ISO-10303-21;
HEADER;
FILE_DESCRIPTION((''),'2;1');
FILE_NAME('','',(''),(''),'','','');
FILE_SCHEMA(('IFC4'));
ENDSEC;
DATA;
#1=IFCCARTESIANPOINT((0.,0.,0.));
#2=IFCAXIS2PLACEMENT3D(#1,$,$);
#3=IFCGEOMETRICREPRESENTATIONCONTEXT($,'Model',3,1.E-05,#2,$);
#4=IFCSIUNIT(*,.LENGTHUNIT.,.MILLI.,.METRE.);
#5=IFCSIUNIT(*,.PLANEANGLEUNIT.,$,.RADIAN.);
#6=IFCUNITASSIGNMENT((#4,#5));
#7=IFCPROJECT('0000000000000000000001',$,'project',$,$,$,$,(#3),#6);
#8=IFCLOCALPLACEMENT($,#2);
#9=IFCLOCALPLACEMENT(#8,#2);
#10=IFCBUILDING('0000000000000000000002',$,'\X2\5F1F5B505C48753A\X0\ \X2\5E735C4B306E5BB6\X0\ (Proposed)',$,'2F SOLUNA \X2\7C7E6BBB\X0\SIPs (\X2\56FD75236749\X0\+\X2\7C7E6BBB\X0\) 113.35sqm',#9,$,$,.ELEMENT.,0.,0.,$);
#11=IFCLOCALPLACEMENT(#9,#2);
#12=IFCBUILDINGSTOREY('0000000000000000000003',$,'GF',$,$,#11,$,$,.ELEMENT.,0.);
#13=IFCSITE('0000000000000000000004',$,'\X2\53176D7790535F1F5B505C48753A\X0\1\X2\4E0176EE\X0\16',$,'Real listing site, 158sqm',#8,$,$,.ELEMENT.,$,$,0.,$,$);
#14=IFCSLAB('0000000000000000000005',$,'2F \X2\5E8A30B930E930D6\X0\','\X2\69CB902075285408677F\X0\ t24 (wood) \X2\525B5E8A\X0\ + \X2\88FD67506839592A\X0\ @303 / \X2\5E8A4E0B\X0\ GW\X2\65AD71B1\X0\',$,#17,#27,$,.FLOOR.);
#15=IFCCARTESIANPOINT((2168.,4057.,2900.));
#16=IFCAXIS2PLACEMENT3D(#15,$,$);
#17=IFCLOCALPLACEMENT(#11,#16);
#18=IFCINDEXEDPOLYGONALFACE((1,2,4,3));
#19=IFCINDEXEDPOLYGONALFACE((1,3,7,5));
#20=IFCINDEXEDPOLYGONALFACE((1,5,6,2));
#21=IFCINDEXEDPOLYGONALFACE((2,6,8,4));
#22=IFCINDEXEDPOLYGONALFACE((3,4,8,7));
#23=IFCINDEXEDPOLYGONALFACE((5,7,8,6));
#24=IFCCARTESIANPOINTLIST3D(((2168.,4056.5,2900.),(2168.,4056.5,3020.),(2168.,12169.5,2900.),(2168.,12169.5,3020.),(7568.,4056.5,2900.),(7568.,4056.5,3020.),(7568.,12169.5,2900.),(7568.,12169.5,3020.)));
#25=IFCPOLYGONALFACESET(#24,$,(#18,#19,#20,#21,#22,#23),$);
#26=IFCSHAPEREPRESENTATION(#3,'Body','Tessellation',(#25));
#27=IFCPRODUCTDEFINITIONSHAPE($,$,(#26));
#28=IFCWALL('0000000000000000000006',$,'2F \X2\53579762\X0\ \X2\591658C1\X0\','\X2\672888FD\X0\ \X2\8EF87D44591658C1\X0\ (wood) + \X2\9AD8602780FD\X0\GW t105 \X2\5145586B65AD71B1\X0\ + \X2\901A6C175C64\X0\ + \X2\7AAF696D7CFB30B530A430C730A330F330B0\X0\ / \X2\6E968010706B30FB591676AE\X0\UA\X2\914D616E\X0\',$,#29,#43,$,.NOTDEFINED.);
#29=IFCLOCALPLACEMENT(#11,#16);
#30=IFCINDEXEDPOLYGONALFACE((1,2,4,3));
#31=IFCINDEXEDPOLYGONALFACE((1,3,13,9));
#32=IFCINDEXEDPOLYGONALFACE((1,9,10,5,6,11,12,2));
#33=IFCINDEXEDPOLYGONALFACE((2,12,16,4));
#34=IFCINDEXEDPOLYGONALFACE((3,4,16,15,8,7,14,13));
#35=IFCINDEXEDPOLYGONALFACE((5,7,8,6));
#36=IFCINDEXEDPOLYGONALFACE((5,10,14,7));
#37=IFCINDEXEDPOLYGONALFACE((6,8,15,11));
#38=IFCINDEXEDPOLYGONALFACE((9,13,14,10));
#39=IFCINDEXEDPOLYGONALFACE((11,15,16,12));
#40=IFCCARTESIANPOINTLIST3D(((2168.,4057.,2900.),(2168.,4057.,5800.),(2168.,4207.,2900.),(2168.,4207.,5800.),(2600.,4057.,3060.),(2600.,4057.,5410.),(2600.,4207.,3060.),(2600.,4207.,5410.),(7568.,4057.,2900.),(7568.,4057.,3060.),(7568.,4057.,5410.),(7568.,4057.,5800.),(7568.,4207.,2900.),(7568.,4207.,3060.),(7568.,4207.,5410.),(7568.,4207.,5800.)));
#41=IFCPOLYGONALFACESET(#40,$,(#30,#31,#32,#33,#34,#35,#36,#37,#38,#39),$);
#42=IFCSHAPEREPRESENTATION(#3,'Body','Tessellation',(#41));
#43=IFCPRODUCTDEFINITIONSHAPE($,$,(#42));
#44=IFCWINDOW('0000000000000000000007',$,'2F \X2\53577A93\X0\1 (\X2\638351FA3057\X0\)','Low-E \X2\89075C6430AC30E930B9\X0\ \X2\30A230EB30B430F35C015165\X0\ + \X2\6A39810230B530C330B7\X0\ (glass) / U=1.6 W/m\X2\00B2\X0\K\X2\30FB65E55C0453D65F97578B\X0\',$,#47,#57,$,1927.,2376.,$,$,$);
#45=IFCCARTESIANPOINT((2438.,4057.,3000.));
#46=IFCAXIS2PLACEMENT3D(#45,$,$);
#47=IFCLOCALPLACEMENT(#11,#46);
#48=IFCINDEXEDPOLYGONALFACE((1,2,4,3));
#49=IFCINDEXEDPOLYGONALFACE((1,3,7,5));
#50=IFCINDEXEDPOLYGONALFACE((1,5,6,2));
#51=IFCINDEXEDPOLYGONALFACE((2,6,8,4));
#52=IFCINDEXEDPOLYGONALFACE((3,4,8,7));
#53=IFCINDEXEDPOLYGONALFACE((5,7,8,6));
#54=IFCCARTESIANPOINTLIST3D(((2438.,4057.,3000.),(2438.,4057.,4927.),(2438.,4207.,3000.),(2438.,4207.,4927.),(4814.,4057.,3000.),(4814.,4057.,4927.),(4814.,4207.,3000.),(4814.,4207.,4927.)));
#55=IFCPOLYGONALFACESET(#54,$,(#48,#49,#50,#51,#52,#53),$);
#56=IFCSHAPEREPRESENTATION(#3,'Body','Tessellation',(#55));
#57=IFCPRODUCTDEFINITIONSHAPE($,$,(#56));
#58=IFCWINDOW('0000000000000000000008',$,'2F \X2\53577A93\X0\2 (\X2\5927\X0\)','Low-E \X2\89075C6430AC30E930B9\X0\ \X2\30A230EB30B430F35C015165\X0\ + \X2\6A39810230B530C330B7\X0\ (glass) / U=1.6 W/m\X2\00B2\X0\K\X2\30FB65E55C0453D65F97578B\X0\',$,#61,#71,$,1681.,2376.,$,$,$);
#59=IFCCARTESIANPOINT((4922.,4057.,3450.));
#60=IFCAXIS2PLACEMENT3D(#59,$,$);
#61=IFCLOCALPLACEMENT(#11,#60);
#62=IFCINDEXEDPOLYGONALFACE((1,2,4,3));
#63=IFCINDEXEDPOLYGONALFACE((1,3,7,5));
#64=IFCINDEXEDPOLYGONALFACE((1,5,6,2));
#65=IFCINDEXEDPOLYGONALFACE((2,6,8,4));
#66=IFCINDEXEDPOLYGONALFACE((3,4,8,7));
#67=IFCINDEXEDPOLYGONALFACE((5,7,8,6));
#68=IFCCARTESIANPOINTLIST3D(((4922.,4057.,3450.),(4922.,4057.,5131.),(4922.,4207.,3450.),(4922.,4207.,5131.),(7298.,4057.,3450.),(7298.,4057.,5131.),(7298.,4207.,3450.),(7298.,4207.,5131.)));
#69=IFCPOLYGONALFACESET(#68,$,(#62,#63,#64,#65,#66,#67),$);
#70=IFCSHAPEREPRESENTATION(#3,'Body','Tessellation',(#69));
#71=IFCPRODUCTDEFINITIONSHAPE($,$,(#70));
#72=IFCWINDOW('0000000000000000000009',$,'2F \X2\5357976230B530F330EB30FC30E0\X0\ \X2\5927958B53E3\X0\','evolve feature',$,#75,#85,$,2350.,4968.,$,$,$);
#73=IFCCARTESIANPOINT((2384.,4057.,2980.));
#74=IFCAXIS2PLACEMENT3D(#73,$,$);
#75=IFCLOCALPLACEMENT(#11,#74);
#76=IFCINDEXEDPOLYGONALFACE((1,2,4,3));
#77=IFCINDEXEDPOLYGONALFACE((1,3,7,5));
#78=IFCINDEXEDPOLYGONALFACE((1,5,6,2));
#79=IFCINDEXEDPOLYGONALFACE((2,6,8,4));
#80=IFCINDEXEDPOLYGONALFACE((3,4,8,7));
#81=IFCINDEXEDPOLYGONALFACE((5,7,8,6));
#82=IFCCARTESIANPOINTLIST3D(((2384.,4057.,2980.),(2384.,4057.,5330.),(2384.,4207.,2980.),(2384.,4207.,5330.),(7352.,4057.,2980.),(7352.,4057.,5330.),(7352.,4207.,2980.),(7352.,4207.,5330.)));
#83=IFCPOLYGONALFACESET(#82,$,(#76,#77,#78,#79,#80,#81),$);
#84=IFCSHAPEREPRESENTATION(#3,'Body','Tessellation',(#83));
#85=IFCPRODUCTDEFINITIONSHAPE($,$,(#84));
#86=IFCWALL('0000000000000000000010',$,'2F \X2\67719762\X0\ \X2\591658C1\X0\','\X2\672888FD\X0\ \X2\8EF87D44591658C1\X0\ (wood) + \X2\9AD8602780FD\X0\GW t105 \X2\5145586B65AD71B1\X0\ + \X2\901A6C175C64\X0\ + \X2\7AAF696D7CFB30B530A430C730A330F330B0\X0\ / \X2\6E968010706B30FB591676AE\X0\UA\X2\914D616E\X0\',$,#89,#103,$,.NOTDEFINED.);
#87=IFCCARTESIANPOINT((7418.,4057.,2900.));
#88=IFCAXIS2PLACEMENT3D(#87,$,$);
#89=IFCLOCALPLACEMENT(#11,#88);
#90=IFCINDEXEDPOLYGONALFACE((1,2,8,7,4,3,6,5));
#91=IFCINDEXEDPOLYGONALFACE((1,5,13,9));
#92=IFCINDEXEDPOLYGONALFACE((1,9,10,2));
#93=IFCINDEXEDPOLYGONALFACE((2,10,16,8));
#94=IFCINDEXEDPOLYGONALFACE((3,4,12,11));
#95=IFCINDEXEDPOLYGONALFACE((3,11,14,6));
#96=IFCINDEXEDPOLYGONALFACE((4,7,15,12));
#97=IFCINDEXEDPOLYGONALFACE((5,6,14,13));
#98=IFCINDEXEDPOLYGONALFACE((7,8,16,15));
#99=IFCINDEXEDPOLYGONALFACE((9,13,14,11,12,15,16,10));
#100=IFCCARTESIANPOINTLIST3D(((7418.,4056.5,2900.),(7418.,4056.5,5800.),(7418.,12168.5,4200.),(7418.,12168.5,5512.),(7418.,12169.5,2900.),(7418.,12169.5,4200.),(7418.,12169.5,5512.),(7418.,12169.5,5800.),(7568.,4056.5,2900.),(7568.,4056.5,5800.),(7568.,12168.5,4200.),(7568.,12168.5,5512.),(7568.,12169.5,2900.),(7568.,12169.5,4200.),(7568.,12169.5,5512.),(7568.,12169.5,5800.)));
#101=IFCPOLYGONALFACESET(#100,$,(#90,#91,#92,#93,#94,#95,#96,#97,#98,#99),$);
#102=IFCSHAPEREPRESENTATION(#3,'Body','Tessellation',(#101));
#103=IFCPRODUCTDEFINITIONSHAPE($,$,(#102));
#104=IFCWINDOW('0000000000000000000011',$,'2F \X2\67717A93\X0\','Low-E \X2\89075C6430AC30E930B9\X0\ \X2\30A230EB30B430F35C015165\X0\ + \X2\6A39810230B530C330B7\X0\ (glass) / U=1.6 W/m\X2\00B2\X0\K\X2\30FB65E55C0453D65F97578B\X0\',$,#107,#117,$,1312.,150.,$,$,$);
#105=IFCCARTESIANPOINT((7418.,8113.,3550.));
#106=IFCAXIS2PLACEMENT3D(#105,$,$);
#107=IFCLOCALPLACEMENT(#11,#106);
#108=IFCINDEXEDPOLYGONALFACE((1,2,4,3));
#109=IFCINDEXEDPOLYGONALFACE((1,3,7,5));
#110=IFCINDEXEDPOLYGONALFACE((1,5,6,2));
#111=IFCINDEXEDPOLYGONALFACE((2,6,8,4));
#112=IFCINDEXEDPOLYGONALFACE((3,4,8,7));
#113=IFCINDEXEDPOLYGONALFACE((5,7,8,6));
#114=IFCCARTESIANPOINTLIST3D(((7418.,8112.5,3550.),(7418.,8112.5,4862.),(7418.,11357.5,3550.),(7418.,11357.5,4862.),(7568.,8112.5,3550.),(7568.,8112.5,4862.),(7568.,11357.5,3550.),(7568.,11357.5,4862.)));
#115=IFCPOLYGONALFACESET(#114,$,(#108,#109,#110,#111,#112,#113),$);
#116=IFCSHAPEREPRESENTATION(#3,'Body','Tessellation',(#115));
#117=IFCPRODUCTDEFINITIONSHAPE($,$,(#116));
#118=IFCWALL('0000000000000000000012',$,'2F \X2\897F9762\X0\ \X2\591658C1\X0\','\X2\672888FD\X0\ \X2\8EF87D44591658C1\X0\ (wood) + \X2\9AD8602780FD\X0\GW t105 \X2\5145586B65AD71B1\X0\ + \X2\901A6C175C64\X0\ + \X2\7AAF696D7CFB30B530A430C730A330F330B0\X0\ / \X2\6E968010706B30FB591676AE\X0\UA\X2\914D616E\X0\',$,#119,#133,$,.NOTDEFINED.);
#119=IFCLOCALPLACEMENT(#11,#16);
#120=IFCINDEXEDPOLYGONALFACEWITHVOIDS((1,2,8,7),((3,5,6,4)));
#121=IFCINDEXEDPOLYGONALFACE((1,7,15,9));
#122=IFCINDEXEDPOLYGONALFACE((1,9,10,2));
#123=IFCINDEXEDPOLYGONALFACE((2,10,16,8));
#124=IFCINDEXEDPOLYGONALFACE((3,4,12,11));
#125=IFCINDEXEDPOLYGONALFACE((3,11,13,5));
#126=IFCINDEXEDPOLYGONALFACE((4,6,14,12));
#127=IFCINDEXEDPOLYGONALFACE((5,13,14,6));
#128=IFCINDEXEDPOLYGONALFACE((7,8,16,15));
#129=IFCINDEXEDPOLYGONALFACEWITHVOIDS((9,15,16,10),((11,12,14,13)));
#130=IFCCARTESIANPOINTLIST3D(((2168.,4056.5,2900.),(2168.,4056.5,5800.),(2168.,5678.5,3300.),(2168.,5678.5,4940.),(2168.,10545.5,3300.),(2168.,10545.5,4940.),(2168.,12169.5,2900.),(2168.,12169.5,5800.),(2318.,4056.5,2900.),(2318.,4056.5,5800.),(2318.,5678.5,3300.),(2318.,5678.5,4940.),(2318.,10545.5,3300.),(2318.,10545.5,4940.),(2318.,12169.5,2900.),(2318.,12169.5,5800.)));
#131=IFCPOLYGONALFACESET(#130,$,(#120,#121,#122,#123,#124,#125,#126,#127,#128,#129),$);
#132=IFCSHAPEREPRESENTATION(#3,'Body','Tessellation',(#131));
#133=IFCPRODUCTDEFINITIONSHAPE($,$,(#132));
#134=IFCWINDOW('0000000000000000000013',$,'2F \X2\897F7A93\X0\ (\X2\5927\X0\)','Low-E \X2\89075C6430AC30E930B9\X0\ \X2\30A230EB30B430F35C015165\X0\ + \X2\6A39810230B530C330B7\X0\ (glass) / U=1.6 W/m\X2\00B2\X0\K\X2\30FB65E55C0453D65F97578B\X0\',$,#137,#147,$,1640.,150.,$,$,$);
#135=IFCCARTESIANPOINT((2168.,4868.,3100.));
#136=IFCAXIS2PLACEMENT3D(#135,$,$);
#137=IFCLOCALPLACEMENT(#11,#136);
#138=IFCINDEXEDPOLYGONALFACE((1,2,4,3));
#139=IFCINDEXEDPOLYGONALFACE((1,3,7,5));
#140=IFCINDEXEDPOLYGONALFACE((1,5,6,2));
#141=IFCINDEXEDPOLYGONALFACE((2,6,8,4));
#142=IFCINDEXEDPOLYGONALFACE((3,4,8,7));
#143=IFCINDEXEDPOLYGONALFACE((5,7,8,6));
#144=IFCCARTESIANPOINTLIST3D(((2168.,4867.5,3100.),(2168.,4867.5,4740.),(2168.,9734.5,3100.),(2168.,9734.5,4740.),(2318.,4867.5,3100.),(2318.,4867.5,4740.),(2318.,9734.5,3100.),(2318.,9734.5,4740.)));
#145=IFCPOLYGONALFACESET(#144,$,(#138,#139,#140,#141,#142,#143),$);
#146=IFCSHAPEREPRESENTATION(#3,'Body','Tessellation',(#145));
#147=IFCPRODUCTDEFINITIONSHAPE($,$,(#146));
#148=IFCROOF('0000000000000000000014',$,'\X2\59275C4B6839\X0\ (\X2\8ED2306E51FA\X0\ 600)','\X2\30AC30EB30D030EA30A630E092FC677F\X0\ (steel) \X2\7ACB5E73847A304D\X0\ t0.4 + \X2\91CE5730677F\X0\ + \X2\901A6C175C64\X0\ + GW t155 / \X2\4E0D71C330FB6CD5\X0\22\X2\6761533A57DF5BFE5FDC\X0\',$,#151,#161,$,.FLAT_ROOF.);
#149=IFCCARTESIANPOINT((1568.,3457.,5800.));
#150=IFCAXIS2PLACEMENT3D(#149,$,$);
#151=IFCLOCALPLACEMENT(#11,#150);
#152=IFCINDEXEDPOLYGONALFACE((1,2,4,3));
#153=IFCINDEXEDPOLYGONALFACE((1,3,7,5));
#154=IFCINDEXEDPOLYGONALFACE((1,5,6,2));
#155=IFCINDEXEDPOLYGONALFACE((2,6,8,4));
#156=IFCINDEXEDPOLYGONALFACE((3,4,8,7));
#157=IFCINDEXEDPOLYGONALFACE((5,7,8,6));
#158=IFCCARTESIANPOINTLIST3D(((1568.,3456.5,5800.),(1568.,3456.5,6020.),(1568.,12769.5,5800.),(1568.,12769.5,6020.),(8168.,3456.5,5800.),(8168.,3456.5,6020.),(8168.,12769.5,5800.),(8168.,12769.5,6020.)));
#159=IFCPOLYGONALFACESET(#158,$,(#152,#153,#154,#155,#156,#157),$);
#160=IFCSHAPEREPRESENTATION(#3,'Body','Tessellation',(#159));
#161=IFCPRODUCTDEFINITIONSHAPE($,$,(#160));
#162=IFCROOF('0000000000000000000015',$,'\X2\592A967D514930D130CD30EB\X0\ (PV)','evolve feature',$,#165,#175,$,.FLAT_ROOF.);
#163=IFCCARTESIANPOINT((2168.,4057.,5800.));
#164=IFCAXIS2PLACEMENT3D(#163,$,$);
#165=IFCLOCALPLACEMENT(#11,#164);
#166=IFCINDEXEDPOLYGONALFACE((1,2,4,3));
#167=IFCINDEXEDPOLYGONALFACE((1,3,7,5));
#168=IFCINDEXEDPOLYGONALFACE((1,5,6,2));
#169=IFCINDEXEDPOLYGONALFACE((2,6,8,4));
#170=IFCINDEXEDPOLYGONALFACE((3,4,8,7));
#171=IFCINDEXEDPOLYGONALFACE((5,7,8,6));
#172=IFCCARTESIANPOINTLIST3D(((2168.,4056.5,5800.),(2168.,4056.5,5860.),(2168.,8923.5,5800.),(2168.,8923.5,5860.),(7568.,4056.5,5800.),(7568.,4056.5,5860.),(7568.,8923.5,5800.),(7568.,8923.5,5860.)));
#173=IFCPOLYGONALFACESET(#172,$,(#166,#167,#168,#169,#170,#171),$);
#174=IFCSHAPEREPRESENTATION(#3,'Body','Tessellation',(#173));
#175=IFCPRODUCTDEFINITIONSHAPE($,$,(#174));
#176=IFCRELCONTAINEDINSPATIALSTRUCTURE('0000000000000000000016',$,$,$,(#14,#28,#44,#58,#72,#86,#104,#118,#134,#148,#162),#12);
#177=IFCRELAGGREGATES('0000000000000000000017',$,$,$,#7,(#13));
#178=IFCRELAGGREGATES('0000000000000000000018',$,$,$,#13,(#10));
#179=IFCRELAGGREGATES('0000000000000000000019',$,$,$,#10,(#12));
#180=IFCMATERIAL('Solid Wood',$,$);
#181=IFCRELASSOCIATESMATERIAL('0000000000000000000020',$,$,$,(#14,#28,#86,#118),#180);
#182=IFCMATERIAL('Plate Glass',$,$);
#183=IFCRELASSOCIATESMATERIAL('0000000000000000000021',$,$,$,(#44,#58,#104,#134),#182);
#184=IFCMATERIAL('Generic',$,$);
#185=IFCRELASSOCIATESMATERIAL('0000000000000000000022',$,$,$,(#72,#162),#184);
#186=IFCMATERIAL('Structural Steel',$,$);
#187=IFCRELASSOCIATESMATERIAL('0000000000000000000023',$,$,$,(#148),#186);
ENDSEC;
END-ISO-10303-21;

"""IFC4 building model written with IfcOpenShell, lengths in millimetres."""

from ifc_helpers import new_model, si_unit, frame, frame_2d, origin, place, context, project, spatial, rectangle, extrude, material, element, fill, save


model = new_model("IFC4")

# Units and contexts
model_context = context("Model", 3, precision=1e-05, world=origin())
ifc_project = project(units=[si_unit("LENGTHUNIT", "METRE", prefix="MILLI"), si_unit("PLANEANGLEUNIT", "RADIAN")], contexts=[model_context])

# Site, building, storey
site_placement = place(None, origin())
site = spatial("IfcSite", under=ifc_project, at=site_placement, Name="北海道弟子屈町1丁目16", ObjectType="Real listing site, 158sqm", CompositionType="ELEMENT", RefElevation=0.0)
building_placement = place(site_placement, origin())
building = spatial("IfcBuilding", under=site, at=building_placement, Name="弟子屈町 平屋の家 (Proposed)", ObjectType="2F SOLUNA 籾殻SIPs (国産杉+籾殻) 113.35sqm", CompositionType="ELEMENT", ElevationOfRefHeight=0.0, ElevationOfTerrain=0.0)
storey_placement = place(building_placement, origin())
storey = spatial("IfcBuildingStorey", under=building, at=storey_placement, Name="GF", CompositionType="ELEMENT", Elevation=0.0)

# Slab
ifc_material_1 = material(Name="Solid Wood")
slab_placement = place(storey_placement, frame((2168.0, 4057.0, 2900.0)))
element("IfcSlab", 1, at=slab_placement, inside=storey, material=ifc_material_1, Name="2F 床スラブ", Description="構造用合板 t24 (wood) 剛床 + 製材根太 @303 / 床下 GW断熱", PredefinedType="FLOOR", context=model_context, shape_type="SweptSolid", body=[
    extrude(rectangle(XDim=5400.0, YDim=8113.0, at=frame_2d((2700.0, 4056.0))), frame((2168.0, 4057.0, 2900.0)), (0.0, 0.0, 1.0), 120.0),
])

# Wall, openings, windows
wall_1_placement = place(storey_placement, frame((2168.0, 4057.0, 2900.0)))
wall_1 = element("IfcWall", 2, at=wall_1_placement, inside=storey, material=ifc_material_1, Name="2F 南面 外壁", Description="木製 軸組外壁 (wood) + 高性能GW t105 充填断熱 + 通気層 + 窯業系サイディング / 準耐火・外皮UA配慮", PredefinedType="NOTDEFINED", context=model_context, shape_type="SweptSolid", body=[
    extrude(rectangle(XDim=5400.0, YDim=150.0, at=frame_2d((2700.0, 75.0))), frame((2168.0, 4057.0, 2900.0)), (0.0, 0.0, 1.0), 2900.0),
])
opening_1_placement = place(storey_placement, frame((2438.0, 4057.0, 3000.0)))
opening_1 = element("IfcOpeningElement", 3, at=opening_1_placement, cuts=wall_1, PredefinedType="NOTDEFINED", context=model_context, shape_type="SweptSolid", body=[
    extrude(rectangle(XDim=2376.0, YDim=150.0, at=frame_2d((1188.0, 75.0))), frame((2438.0, 4057.0, 3000.0)), (0.0, 0.0, 1.0), 1927.0),
])
opening_2_placement = place(storey_placement, frame((4922.0, 4057.0, 3450.0)))
opening_2 = element("IfcOpeningElement", 4, at=opening_2_placement, cuts=wall_1, PredefinedType="NOTDEFINED", context=model_context, shape_type="SweptSolid", body=[
    extrude(rectangle(XDim=2376.0, YDim=150.0, at=frame_2d((1188.0, 75.0))), frame((4922.0, 4057.0, 3450.0)), (0.0, 0.0, 1.0), 1681.0),
])
opening_3_placement = place(storey_placement, frame((2384.0, 4057.0, 2980.0)))
opening_3 = element("IfcOpeningElement", 5, at=opening_3_placement, cuts=wall_1, PredefinedType="NOTDEFINED", context=model_context, shape_type="SweptSolid", body=[
    extrude(rectangle(XDim=4968.0, YDim=150.0, at=frame_2d((2484.0, 75.0))), frame((2384.0, 4057.0, 2980.0)), (0.0, 0.0, 1.0), 2350.0),
])
ifc_material_2 = material(Name="Plate Glass")
window_1_placement = place(storey_placement, frame((2438.0, 4057.0, 3000.0)))
window_1 = element("IfcWindow", 6, at=window_1_placement, inside=storey, material=ifc_material_2, Name="2F 南窓1 (掃出し)", Description="Low-E 複層ガラス アルゴン封入 + 樹脂サッシ (glass) / U=1.6 W/m²K・日射取得型", OverallHeight=1927.0, OverallWidth=2376.0, context=model_context, shape_type="SweptSolid", body=[
    extrude(rectangle(XDim=2376.0, YDim=150.0, at=frame_2d((1188.0, 75.0))), frame((2438.0, 4057.0, 3000.0)), (0.0, 0.0, 1.0), 1927.0),
])
fill(opening_1, window_1)
window_2_placement = place(storey_placement, frame((4922.0, 4057.0, 3450.0)))
window_2 = element("IfcWindow", 7, at=window_2_placement, inside=storey, material=ifc_material_2, Name="2F 南窓2 (大)", Description="Low-E 複層ガラス アルゴン封入 + 樹脂サッシ (glass) / U=1.6 W/m²K・日射取得型", OverallHeight=1681.0, OverallWidth=2376.0, context=model_context, shape_type="SweptSolid", body=[
    extrude(rectangle(XDim=2376.0, YDim=150.0, at=frame_2d((1188.0, 75.0))), frame((4922.0, 4057.0, 3450.0)), (0.0, 0.0, 1.0), 1681.0),
])
fill(opening_2, window_2)
ifc_material_3 = material(Name="Generic")
window_3_placement = place(storey_placement, frame((2384.0, 4057.0, 2980.0)))
window_3 = element("IfcWindow", 8, at=window_3_placement, inside=storey, material=ifc_material_3, Name="2F 南面サンルーム 大開口", Description="evolve feature", OverallHeight=2350.0, OverallWidth=4968.0, context=model_context, shape_type="SweptSolid", body=[
    extrude(rectangle(XDim=4968.0, YDim=150.0, at=frame_2d((2484.0, 75.0))), frame((2384.0, 4057.0, 2980.0)), (0.0, 0.0, 1.0), 2350.0),
])
fill(opening_3, window_3)

# Walls, openings, windows
wall_2_placement = place(storey_placement, frame((7418.0, 4057.0, 2900.0)))
wall_2 = element("IfcWall", 9, at=wall_2_placement, inside=storey, material=ifc_material_1, Name="2F 東面 外壁", Description="木製 軸組外壁 (wood) + 高性能GW t105 充填断熱 + 通気層 + 窯業系サイディング / 準耐火・外皮UA配慮", PredefinedType="NOTDEFINED", context=model_context, shape_type="SweptSolid", body=[
    extrude(rectangle(XDim=150.0, YDim=8113.0, at=frame_2d((75.0, 4056.0))), frame((7418.0, 4057.0, 2900.0)), (0.0, 0.0, 1.0), 2900.0),
])
opening_4_placement = place(storey_placement, frame((7418.0, 8113.0, 3550.0)))
opening_4 = element("IfcOpeningElement", 10, at=opening_4_placement, cuts=wall_2, PredefinedType="NOTDEFINED", context=model_context, shape_type="SweptSolid", body=[
    extrude(rectangle(XDim=150.0, YDim=3245.0, at=frame_2d((75.0, 1622.0))), frame((7418.0, 8113.0, 3550.0)), (0.0, 0.0, 1.0), 1312.0),
])
window_4_placement = place(storey_placement, frame((7418.0, 8113.0, 3550.0)))
window_4 = element("IfcWindow", 11, at=window_4_placement, inside=storey, material=ifc_material_2, Name="2F 東窓", Description="Low-E 複層ガラス アルゴン封入 + 樹脂サッシ (glass) / U=1.6 W/m²K・日射取得型", OverallHeight=1312.0, OverallWidth=150.0, context=model_context, shape_type="SweptSolid", body=[
    extrude(rectangle(XDim=150.0, YDim=3245.0, at=frame_2d((75.0, 1622.0))), frame((7418.0, 8113.0, 3550.0)), (0.0, 0.0, 1.0), 1312.0),
])
fill(opening_4, window_4)
wall_3_placement = place(storey_placement, frame((2168.0, 4057.0, 2900.0)))
wall_3 = element("IfcWall", 12, at=wall_3_placement, inside=storey, material=ifc_material_1, Name="2F 西面 外壁", Description="木製 軸組外壁 (wood) + 高性能GW t105 充填断熱 + 通気層 + 窯業系サイディング / 準耐火・外皮UA配慮", PredefinedType="NOTDEFINED", context=model_context, shape_type="SweptSolid", body=[
    extrude(rectangle(XDim=150.0, YDim=8113.0, at=frame_2d((75.0, 4056.0))), frame((2168.0, 4057.0, 2900.0)), (0.0, 0.0, 1.0), 2900.0),
])
opening_5_placement = place(storey_placement, frame((2168.0, 4868.0, 3100.0)))
opening_5 = element("IfcOpeningElement", 13, at=opening_5_placement, cuts=wall_3, PredefinedType="NOTDEFINED", context=model_context, shape_type="SweptSolid", body=[
    extrude(rectangle(XDim=150.0, YDim=4867.0, at=frame_2d((75.0, 2433.0))), frame((2168.0, 4868.0, 3100.0)), (0.0, 0.0, 1.0), 1640.0),
])
window_5_placement = place(storey_placement, frame((2168.0, 4868.0, 3100.0)))
window_5 = element("IfcWindow", 14, at=window_5_placement, inside=storey, material=ifc_material_2, Name="2F 西窓 (大)", Description="Low-E 複層ガラス アルゴン封入 + 樹脂サッシ (glass) / U=1.6 W/m²K・日射取得型", OverallHeight=1640.0, OverallWidth=150.0, context=model_context, shape_type="SweptSolid", body=[
    extrude(rectangle(XDim=150.0, YDim=4867.0, at=frame_2d((75.0, 2433.0))), frame((2168.0, 4868.0, 3100.0)), (0.0, 0.0, 1.0), 1640.0),
])
fill(opening_5, window_5)

# Roofs
ifc_material_4 = material(Name="Structural Steel")
roof_1_placement = place(storey_placement, frame((1568.0, 3457.0, 5800.0)))
element("IfcRoof", 15, at=roof_1_placement, inside=storey, material=ifc_material_4, Name="大屋根 (軒の出 600)", Description="ガルバリウム鋼板 (steel) 立平葺き t0.4 + 野地板 + 通気層 + GW t155 / 不燃・法22条区域対応", PredefinedType="FLAT_ROOF", context=model_context, shape_type="SweptSolid", body=[
    extrude(rectangle(XDim=6600.0, YDim=9313.0, at=frame_2d((3300.0, 4656.0))), frame((1568.0, 3457.0, 5800.0)), (0.0, 0.0, 1.0), 220.0),
])
roof_2_placement = place(storey_placement, frame((2168.0, 4057.0, 5800.0)))
element("IfcRoof", 16, at=roof_2_placement, inside=storey, material=ifc_material_3, Name="太陽光パネル (PV)", Description="evolve feature", PredefinedType="FLAT_ROOF", context=model_context, shape_type="SweptSolid", body=[
    extrude(rectangle(XDim=5400.0, YDim=4867.0, at=frame_2d((2700.0, 2433.0))), frame((2168.0, 4057.0, 5800.0)), (0.0, 0.0, 1.0), 60.0),
])

save(model, "model.ifc")
